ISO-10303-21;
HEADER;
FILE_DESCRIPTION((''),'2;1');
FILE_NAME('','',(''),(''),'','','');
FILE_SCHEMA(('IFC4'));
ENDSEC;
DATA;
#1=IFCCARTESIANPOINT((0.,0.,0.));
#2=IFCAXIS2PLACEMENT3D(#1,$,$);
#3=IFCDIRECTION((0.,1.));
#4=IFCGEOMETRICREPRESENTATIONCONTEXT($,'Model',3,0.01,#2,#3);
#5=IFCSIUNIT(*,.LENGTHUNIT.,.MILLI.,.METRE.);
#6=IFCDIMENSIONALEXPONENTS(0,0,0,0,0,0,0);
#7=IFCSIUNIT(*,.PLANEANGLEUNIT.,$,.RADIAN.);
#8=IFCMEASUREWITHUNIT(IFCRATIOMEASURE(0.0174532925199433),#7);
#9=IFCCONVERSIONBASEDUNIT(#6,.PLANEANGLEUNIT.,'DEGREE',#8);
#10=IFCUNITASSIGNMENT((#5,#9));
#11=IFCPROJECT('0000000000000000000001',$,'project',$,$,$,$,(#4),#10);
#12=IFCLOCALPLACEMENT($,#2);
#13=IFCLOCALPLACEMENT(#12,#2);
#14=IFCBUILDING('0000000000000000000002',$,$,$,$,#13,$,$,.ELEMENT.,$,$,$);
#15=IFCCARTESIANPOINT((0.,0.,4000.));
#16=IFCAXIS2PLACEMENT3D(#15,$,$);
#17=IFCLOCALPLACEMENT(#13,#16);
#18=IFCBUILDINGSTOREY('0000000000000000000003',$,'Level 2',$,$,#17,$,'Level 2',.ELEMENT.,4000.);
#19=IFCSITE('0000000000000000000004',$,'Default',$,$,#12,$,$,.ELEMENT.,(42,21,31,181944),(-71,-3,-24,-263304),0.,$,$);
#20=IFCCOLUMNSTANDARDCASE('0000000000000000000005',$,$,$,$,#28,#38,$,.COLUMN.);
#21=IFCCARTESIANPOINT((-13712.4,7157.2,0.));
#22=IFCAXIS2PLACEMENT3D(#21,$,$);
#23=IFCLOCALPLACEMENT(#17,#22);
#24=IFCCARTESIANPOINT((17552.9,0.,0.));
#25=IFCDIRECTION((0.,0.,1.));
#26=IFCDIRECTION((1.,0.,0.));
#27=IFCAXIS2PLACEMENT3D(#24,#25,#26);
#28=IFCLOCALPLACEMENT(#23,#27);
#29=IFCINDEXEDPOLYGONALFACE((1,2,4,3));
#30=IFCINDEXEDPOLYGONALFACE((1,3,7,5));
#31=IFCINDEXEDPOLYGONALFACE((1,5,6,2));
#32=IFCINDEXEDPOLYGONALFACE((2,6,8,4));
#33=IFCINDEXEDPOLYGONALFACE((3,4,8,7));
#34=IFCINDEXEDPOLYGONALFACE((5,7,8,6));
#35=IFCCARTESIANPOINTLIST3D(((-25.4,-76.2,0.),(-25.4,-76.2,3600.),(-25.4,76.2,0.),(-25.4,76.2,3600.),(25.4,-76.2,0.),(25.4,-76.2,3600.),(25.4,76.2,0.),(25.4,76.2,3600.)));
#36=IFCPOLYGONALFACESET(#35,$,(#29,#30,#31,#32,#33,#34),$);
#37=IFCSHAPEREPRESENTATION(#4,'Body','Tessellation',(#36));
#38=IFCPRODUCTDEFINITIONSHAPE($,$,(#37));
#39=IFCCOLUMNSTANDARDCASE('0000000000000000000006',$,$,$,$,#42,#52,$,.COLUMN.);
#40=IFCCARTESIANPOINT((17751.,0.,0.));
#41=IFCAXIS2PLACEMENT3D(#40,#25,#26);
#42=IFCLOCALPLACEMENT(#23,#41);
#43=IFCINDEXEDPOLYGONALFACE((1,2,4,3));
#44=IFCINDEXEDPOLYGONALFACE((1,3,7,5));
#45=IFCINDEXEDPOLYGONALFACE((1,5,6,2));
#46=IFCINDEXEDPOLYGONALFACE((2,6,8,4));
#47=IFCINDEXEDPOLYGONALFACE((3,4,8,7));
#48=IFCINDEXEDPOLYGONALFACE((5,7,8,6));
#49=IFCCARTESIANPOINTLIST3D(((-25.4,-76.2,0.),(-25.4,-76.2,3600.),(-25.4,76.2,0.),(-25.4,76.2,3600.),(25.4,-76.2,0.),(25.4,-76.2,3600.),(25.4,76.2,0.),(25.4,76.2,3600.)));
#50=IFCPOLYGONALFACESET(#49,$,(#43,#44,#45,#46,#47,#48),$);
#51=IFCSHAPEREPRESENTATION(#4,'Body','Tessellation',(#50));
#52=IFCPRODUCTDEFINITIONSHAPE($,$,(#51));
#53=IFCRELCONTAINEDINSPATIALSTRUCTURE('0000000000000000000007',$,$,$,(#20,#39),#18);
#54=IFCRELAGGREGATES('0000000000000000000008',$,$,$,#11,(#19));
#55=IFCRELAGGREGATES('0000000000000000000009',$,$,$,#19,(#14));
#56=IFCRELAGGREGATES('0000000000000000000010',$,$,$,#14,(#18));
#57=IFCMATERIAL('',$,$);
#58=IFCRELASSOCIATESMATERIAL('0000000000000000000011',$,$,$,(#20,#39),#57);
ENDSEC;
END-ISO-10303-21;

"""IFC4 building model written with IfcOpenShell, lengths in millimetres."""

from ifc_helpers import new_model, entity, si_unit, converted_unit, direction, frame, origin, place, context, project, spatial, rectangle, extrude, material, element, save


model = new_model("IFC4")

# Units and contexts
model_context = context("Model", 3, precision=0.01, world=origin(), true_north=direction((0.0, 1.0)))
ifc_project = project(units=[si_unit("LENGTHUNIT", "METRE", prefix="MILLI"), converted_unit("PLANEANGLEUNIT", "DEGREE", entity("IfcRatioMeasure", 0.0174532925199433), si_unit("PLANEANGLEUNIT", "RADIAN"), dimensions=[0, 0, 0, 0, 0, 0, 0])], contexts=[model_context])

# Site, building, storey
site_placement = place(None, origin())
site = spatial("IfcSite", under=ifc_project, at=site_placement, Name="Default", CompositionType="ELEMENT", RefLatitude=(42, 21, 31, 181944), RefLongitude=(-71, -3, -24, -263304), RefElevation=0.0)
building_placement = place(site_placement, origin())
building = spatial("IfcBuilding", under=site, at=building_placement, CompositionType="ELEMENT")
storey_placement = place(building_placement, frame((0.0, 0.0, 4000.0)))
storey = spatial("IfcBuildingStorey", under=building, at=storey_placement, Name="Level 2", LongName="Level 2", CompositionType="ELEMENT", Elevation=4000.0)

# Columns
placement_1 = place(storey_placement, frame((-13712.4, 7157.2, 0.0)))
ifc_material_1 = material(Name="")
for number, where, z_axis, x_axis in (
    (1, (17552.9, 0.0, 0.0), (0.0, 0.0, 1.0), (1.0, 0.0, 0.0)),
    (2, (17751.0, 0.0, 0.0), (0.0, 0.0, 1.0), (1.0, 0.0, 0.0)),
):
    element("IfcColumnStandardCase", number, at=place(placement_1, frame(where, z_axis=z_axis, x_axis=x_axis)), inside=storey, material=ifc_material_1, PredefinedType="COLUMN", context=model_context, shape_type="SweptSolid", body=[
        extrude(rectangle(XDim=50.8, YDim=152.4), origin(), (0.0, 0.0, 1.0), 3600.0),
    ])

save(model, "model.ifc")
